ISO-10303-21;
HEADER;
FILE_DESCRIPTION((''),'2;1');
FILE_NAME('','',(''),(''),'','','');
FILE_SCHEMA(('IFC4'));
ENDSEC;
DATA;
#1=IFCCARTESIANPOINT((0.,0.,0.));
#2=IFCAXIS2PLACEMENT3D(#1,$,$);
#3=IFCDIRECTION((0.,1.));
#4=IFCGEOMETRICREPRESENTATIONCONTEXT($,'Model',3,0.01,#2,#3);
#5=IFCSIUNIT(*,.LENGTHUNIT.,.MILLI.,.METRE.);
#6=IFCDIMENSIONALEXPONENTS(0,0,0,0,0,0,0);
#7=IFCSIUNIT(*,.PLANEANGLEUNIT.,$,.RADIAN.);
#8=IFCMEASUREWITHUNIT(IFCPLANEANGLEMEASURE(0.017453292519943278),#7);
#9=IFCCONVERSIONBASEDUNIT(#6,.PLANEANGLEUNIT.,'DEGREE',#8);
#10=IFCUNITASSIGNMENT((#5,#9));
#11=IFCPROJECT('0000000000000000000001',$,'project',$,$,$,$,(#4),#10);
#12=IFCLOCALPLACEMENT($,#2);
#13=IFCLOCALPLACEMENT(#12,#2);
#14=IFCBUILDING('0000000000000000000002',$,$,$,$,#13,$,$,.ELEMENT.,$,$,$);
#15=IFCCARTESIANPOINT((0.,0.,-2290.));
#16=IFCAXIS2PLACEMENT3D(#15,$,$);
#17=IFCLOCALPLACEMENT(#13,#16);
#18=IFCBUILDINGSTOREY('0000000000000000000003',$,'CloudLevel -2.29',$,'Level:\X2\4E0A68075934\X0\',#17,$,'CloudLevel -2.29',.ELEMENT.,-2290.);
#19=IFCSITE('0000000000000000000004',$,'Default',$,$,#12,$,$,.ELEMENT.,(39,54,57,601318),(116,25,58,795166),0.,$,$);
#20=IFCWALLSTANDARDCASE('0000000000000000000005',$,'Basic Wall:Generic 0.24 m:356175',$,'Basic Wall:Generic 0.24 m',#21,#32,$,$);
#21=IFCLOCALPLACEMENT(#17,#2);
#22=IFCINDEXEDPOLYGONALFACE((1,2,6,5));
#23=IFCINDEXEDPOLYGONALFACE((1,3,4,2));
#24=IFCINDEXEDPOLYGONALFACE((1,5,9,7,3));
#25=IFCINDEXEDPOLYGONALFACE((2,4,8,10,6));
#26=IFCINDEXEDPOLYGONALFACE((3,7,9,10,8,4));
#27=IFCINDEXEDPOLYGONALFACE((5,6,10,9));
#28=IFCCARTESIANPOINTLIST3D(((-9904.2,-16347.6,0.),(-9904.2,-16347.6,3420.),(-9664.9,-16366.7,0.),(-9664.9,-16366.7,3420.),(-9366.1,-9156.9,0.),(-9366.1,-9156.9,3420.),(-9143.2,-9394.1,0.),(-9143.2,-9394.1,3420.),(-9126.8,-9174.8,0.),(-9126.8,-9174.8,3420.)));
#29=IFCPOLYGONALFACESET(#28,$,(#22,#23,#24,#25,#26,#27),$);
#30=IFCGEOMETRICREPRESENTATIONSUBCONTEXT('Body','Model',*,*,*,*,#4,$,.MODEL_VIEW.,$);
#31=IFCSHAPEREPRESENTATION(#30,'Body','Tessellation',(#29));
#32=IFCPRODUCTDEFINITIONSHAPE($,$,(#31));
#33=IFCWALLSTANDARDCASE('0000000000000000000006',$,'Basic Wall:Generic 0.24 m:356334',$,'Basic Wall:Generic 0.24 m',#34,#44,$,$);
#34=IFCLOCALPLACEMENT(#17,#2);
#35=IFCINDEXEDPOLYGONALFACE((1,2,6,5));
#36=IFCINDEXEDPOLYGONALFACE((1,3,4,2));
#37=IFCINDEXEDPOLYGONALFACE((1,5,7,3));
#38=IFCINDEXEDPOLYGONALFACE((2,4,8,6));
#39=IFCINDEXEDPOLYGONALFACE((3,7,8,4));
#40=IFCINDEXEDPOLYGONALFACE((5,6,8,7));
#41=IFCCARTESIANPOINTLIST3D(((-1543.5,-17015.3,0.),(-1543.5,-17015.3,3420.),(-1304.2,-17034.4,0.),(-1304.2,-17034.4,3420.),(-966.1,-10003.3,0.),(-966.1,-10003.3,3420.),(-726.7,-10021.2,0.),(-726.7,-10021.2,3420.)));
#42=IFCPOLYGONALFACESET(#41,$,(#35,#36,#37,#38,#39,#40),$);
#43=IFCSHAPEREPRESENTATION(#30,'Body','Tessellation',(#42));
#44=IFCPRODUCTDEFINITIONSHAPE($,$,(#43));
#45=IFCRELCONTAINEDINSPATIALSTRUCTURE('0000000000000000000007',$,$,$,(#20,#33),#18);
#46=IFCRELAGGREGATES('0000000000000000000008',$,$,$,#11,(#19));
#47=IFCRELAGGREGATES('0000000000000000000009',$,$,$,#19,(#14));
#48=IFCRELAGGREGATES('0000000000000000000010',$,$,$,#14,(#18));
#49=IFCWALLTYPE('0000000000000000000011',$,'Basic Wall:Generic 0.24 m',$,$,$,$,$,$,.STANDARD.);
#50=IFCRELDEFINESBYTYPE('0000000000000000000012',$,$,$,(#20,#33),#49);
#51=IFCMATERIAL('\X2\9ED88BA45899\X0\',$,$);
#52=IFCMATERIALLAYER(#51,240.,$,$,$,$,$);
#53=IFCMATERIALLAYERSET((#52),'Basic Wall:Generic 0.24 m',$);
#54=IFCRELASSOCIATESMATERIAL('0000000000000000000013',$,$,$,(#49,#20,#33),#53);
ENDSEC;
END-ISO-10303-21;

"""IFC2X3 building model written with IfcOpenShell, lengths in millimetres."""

from ifc_helpers import new_model, entity, si_unit, converted_unit, direction, frame, origin, place, context, subcontext, project, spatial, polyline, outline, extrude, material, layer, layer_set, layer_usage, type_object, element, save


model = new_model("IFC2X3")

# Units and contexts
model_context = context("Model", 3, precision=0.01, world=origin(), true_north=direction((0.0, 1.0)))
body_context = subcontext(model_context, "Body", "Model", "MODEL_VIEW")
ifc_project = project(units=[si_unit("LENGTHUNIT", "METRE", prefix="MILLI"), converted_unit("PLANEANGLEUNIT", "DEGREE", entity("IfcPlaneAngleMeasure", 0.017453292519943278), si_unit("PLANEANGLEUNIT", "RADIAN"), dimensions=[0, 0, 0, 0, 0, 0, 0])], contexts=[model_context])

# Site, building, storey
site_placement = place(None, origin())
site = spatial("IfcSite", under=ifc_project, at=site_placement, Name="Default", CompositionType="ELEMENT", RefLatitude=(39, 54, 57, 601318), RefLongitude=(116, 25, 58, 795166), RefElevation=0.0)
building_placement = place(site_placement, origin())
building = spatial("IfcBuilding", under=site, at=building_placement, CompositionType="ELEMENT")
storey_placement = place(building_placement, frame((0.0, 0.0, -2290.0)))
storey = spatial("IfcBuildingStorey", under=building, at=storey_placement, Name="CloudLevel -2.29", ObjectType="Level:上标头", LongName="CloudLevel -2.29", CompositionType="ELEMENT", Elevation=-2290.0)

# Walls
ifc_material_1 = material(Name="默认墙")
ifc_layer_1 = layer(ifc_material_1, 240.0)
ifc_layer_set_1 = layer_set([ifc_layer_1], Name="Basic Wall:Generic 0.24 m")
ifc_layer_usage_1 = layer_usage(ifc_layer_set_1, "AXIS2", "NEGATIVE", 120.0)
wall_type_1 = type_object("IfcWallType", Name="Basic Wall:Generic 0.24 m", PredefinedType="STANDARD", material=ifc_layer_set_1)
wall_1_placement = place(storey_placement, frame((-9246.4, -9165.8, 0.0), z_axis=(0.0, 0.0, 1.0), x_axis=(-0.074621, -0.997212, 0.0)))
element("IfcWallStandardCase", 1, at=wall_1_placement, inside=storey, type_object=wall_type_1, material=ifc_layer_usage_1, Name="Basic Wall:Generic 0.24 m:356175", ObjectType="Basic Wall:Generic 0.24 m", context=body_context, shape_type="SweptSolid", body=[
    extrude(outline(polyline([(7210.8, -120.0), (7212.0, 120.0), (220.0, 120.0), (0.0, 120.0), (0.1, -120.0), (7210.8, -120.0)])), origin(), (0.0, 0.0, 1.0), 3420.0),
])
wall_2_placement = place(storey_placement, frame((-1423.9, -17025.1, 0.0), z_axis=(0.0, 0.0, 1.0), x_axis=(0.082071, 0.996627, 0.0)))
element("IfcWallStandardCase", 2, at=wall_2_placement, inside=storey, type_object=wall_type_1, material=ifc_layer_usage_1, Name="Basic Wall:Generic 0.24 m:356334", ObjectType="Basic Wall:Generic 0.24 m", context=body_context, shape_type="SweptSolid", body=[
    extrude(outline(polyline([(7037.5, -120.0), (7035.7, 120.0), (0.0, 120.0), (0.6, -120.0), (7037.5, -120.0)])), origin(), (0.0, 0.0, 1.0), 3420.0),
])

save(model, "model.ifc")
